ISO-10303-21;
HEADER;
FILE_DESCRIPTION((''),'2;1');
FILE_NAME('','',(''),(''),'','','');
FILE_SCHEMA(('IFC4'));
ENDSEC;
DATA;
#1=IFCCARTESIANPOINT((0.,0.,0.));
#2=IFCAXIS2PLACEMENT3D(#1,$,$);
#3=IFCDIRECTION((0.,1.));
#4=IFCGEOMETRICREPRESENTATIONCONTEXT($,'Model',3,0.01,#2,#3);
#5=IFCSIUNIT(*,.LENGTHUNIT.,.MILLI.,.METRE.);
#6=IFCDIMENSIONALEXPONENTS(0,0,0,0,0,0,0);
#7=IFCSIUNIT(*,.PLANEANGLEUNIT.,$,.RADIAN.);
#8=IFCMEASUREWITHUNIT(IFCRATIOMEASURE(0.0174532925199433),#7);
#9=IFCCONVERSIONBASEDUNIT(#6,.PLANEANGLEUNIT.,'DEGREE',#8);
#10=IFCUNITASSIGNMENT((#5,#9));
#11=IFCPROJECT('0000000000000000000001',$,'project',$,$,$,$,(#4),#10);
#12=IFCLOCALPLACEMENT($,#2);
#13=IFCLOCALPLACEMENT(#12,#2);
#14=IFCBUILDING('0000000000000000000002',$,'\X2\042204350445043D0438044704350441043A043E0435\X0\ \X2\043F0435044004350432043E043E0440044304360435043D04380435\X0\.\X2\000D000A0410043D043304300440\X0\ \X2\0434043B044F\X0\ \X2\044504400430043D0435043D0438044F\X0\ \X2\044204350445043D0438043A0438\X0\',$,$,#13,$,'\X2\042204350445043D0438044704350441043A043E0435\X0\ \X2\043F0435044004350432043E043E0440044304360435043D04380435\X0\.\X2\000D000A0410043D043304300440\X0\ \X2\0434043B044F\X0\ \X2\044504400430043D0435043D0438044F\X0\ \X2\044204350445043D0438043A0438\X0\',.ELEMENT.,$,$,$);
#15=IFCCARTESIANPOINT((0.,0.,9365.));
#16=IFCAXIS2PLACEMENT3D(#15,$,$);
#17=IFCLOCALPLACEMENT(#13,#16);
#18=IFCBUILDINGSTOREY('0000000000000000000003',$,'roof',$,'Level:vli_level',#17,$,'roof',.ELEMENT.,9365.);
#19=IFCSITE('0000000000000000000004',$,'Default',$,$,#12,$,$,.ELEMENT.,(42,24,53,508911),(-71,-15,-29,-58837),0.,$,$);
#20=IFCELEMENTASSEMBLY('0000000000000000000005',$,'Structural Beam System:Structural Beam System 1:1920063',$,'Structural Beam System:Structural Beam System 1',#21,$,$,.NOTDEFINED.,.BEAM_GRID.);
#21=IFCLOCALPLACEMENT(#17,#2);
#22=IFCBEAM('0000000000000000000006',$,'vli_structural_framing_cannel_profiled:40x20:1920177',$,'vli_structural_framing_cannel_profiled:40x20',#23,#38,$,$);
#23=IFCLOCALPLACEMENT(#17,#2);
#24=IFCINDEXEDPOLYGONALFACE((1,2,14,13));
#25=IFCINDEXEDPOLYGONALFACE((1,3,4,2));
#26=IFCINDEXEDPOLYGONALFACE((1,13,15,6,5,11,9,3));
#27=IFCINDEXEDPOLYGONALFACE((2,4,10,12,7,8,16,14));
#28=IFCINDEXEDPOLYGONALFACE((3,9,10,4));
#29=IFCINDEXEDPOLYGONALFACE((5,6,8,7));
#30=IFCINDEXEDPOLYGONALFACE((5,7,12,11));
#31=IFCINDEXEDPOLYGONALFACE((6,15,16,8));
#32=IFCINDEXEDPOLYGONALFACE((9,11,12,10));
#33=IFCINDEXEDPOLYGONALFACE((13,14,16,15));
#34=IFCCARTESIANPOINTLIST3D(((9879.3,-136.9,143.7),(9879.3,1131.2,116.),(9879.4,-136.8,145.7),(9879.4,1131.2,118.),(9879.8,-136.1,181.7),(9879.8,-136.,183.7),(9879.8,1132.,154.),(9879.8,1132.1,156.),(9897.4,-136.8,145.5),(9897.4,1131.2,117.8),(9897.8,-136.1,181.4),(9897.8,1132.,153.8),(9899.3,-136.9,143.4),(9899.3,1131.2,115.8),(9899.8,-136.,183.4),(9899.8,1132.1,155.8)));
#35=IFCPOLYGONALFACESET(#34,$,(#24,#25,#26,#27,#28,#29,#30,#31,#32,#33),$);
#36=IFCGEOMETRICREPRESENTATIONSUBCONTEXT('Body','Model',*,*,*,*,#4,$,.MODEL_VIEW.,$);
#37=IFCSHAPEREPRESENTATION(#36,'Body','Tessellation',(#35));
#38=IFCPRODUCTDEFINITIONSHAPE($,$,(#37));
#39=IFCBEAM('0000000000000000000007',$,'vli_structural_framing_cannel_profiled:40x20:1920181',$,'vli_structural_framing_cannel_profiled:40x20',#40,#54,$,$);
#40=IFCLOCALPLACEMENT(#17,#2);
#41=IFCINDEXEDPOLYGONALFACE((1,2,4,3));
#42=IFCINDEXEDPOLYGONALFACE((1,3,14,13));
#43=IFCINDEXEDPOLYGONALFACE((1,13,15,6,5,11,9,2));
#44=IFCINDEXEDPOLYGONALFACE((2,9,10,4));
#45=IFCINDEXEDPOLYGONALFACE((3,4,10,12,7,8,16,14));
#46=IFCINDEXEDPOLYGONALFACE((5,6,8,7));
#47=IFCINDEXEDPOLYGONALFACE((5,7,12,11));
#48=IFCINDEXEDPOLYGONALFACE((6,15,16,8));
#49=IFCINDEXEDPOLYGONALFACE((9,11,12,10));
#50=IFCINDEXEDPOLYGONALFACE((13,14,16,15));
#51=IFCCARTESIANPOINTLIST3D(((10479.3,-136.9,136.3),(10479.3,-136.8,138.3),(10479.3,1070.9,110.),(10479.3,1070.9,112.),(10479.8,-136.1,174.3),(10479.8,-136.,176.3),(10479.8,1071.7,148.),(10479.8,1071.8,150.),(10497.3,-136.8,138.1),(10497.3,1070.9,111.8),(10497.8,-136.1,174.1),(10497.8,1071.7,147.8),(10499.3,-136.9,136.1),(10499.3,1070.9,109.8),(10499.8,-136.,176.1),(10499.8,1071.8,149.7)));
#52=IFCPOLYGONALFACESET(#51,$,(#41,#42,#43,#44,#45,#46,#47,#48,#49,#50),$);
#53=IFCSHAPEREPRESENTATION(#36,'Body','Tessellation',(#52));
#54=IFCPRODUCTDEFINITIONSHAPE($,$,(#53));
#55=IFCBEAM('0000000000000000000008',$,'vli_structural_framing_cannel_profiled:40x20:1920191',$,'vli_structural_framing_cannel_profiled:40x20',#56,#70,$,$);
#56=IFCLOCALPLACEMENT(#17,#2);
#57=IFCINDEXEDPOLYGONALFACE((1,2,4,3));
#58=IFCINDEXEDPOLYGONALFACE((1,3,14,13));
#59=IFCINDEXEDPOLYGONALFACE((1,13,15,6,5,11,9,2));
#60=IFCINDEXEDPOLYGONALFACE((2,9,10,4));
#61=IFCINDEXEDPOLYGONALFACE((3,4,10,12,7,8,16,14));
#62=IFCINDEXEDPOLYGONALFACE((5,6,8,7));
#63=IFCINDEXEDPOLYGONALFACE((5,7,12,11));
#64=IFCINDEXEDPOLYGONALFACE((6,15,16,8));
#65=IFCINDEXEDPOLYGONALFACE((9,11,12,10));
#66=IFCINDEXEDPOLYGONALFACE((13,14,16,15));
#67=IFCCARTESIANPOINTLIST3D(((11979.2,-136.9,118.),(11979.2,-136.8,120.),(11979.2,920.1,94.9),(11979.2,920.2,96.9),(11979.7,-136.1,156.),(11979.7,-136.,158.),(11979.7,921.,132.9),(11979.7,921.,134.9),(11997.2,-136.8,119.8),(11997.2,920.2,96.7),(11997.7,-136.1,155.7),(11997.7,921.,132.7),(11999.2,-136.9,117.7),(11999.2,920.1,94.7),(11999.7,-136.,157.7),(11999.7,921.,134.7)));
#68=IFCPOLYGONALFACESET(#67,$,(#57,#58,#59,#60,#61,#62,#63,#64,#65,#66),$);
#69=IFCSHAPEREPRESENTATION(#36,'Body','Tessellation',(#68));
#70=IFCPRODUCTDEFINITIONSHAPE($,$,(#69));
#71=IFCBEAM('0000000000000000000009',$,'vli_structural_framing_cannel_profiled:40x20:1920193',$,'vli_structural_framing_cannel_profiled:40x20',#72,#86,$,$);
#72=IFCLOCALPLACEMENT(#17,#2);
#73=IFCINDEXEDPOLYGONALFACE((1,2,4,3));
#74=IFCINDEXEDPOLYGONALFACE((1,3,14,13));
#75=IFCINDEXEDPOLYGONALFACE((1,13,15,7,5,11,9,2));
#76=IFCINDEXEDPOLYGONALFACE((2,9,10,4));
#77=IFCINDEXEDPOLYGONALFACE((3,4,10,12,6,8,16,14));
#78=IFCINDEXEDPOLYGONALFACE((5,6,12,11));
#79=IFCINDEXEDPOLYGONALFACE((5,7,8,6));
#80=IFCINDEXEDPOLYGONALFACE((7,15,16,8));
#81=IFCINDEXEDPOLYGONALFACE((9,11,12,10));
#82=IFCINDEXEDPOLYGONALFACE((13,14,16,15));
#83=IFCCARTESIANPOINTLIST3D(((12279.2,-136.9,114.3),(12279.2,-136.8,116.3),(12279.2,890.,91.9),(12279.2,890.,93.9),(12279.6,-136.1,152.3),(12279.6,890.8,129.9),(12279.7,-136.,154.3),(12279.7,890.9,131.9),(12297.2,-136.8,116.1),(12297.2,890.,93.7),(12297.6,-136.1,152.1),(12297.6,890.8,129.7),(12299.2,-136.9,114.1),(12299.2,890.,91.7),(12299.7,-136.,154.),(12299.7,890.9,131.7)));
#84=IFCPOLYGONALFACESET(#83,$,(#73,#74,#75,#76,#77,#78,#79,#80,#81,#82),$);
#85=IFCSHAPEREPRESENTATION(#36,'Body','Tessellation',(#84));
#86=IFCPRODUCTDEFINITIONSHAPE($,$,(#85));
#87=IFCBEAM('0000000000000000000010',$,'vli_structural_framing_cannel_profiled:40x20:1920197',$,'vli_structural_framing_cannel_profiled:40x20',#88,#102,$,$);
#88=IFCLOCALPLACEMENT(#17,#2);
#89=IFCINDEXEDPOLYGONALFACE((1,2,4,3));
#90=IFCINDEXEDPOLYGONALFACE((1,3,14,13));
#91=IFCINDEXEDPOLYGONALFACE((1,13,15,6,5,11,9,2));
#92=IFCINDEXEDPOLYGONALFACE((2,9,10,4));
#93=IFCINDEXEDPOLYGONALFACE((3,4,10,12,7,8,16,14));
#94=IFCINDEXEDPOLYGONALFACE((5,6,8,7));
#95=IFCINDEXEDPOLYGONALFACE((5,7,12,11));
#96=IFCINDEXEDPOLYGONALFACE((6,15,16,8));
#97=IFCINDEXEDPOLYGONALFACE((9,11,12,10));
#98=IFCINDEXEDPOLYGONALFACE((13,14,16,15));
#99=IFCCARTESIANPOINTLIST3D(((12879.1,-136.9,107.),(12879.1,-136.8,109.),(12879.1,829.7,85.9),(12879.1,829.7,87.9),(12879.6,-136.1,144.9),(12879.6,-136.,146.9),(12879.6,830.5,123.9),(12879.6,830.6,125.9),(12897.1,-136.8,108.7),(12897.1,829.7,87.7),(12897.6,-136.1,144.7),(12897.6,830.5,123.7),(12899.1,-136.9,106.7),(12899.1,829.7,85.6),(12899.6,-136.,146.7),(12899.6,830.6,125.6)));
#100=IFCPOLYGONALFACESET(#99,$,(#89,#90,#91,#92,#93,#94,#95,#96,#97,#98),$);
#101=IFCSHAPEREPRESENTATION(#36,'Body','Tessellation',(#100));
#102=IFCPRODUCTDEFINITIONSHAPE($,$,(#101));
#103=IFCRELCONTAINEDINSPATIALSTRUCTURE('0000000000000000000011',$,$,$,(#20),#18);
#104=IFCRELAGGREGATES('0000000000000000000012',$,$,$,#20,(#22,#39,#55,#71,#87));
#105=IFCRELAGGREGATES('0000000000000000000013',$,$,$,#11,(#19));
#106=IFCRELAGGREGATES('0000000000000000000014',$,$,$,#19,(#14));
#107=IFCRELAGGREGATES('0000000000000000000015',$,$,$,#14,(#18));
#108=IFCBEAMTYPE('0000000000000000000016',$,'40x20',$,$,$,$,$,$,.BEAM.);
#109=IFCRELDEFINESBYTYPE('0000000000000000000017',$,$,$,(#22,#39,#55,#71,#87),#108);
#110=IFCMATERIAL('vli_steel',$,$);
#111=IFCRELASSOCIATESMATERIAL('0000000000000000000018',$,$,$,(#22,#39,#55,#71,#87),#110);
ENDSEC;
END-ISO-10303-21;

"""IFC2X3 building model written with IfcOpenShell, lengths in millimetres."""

from ifc_helpers import new_model, entity, si_unit, converted_unit, direction, frame, origin, place, context, subcontext, project, spatial, polyline, outline, extrude, material, type_object, element, aggregate, save


model = new_model("IFC2X3")

# Units and contexts
model_context = context("Model", 3, precision=0.01, world=origin(), true_north=direction((0.0, 1.0)))
body_context = subcontext(model_context, "Body", "Model", "MODEL_VIEW")
ifc_project = project(units=[si_unit("LENGTHUNIT", "METRE", prefix="MILLI"), converted_unit("PLANEANGLEUNIT", "DEGREE", entity("IfcRatioMeasure", 0.0174532925199433), si_unit("PLANEANGLEUNIT", "RADIAN"), dimensions=[0, 0, 0, 0, 0, 0, 0])], contexts=[model_context])

# Site, building, storey
site_placement = place(None, origin())
site = spatial("IfcSite", under=ifc_project, at=site_placement, Name="Default", CompositionType="ELEMENT", RefLatitude=(42, 24, 53, 508911), RefLongitude=(-71, -15, -29, -58837), RefElevation=0.0)
building_placement = place(site_placement, origin())
building = spatial("IfcBuilding", under=site, at=building_placement, Name="Техническое перевооружение.\r\nАнгар для хранения техники", LongName="Техническое перевооружение.\r\nАнгар для хранения техники", CompositionType="ELEMENT")
storey_placement = place(building_placement, frame((0.0, 0.0, 9365.0)))
storey = spatial("IfcBuildingStorey", under=building, at=storey_placement, Name="roof", ObjectType="Level:vli_level", LongName="roof", CompositionType="ELEMENT", Elevation=9365.0)

# Element assembly, beams
ifc_material = material(Name="vli_steel")
beam_type = type_object("IfcBeamType", Name="40x20", PredefinedType="BEAM")
assembly_1_placement = place(storey_placement, origin())
assembly_1 = element("IfcElementAssembly", 1, at=assembly_1_placement, inside=storey, Name="Structural Beam System:Structural Beam System 1:1920063", ObjectType="Structural Beam System:Structural Beam System 1", AssemblyPlace="NOTDEFINED", PredefinedType="BEAM_GRID")
beam_1_placement = place(assembly_1_placement, frame((9899.2, 1145.4, 155.5), z_axis=(0.0, 0.021793, 0.999763), x_axis=(0.0, -0.999763, 0.021793)))
beam_1 = element("IfcBeam", 2, at=beam_1_placement, type_object=beam_type, material=ifc_material, Name="vli_structural_framing_cannel_profiled:40x20:1920177", ObjectType="vli_structural_framing_cannel_profiled:40x20", context=body_context, shape_type="SweptSolid", body=[
    extrude(outline(polyline([(-10.5, -20.0), (9.5, -20.0), (9.5, -18.0), (-8.5, -18.0), (-8.5, 18.0), (9.5, 18.0), (9.5, 20.0), (-10.5, 20.0), (-10.5, -20.0)])), frame((13.4, -10.1, -19.9), z_axis=(1.0, 0.0, 0.0), x_axis=(0.0, -0.999925, 0.012237)), (0.0, 0.0, 1.0), 1268.4),
])
beam_2_placement = place(assembly_1_placement, frame((10499.2, 1085.1, 149.5), z_axis=(0.0, 0.021793, 0.999763), x_axis=(0.0, -0.999763, 0.021793)))
beam_2 = element("IfcBeam", 3, at=beam_2_placement, type_object=beam_type, material=ifc_material, Name="vli_structural_framing_cannel_profiled:40x20:1920181", ObjectType="vli_structural_framing_cannel_profiled:40x20", context=body_context, shape_type="SweptSolid", body=[
    extrude(outline(polyline([(-10.5, -20.0), (9.5, -20.0), (9.5, -18.0), (-8.5, -18.0), (-8.5, 18.0), (9.5, 18.0), (9.5, 20.0), (-10.5, 20.0), (-10.5, -20.0)])), frame((13.4, -10.1, -19.9), z_axis=(1.0, 0.0, 0.0), x_axis=(0.0, -0.999925, 0.012237)), (0.0, 0.0, 1.0), 1208.1),
])
beam_3_placement = place(assembly_1_placement, frame((11999.1, 934.4, 134.4), z_axis=(0.0, 0.021793, 0.999763), x_axis=(0.0, -0.999763, 0.021793)))
beam_3 = element("IfcBeam", 4, at=beam_3_placement, type_object=beam_type, material=ifc_material, Name="vli_structural_framing_cannel_profiled:40x20:1920191", ObjectType="vli_structural_framing_cannel_profiled:40x20", context=body_context, shape_type="SweptSolid", body=[
    extrude(outline(polyline([(-10.5, -20.0), (9.5, -20.0), (9.5, -18.0), (-8.5, -18.0), (-8.5, 18.0), (9.5, 18.0), (9.5, 20.0), (-10.5, 20.0), (-10.5, -20.0)])), frame((13.4, -10.1, -19.9), z_axis=(1.0, 0.0, 0.0), x_axis=(0.0, -0.999925, 0.012237)), (0.0, 0.0, 1.0), 1057.3),
])
beam_4_placement = place(assembly_1_placement, frame((12299.1, 904.2, 131.4), z_axis=(0.0, 0.021793, 0.999763), x_axis=(0.0, -0.999763, 0.021793)))
beam_4 = element("IfcBeam", 5, at=beam_4_placement, type_object=beam_type, material=ifc_material, Name="vli_structural_framing_cannel_profiled:40x20:1920193", ObjectType="vli_structural_framing_cannel_profiled:40x20", context=body_context, shape_type="SweptSolid", body=[
    extrude(outline(polyline([(-10.5, -20.0), (9.5, -20.0), (9.5, -18.0), (-8.5, -18.0), (-8.5, 18.0), (9.5, 18.0), (9.5, 20.0), (-10.5, 20.0), (-10.5, -20.0)])), frame((13.4, -10.1, -19.9), z_axis=(1.0, 0.0, 0.0), x_axis=(0.0, -0.999925, 0.012237)), (0.0, 0.0, 1.0), 1027.1),
])
beam_5_placement = place(assembly_1_placement, frame((12899.0, 843.9, 125.3), z_axis=(0.0, 0.021793, 0.999763), x_axis=(0.0, -0.999763, 0.021793)))
beam_5 = element("IfcBeam", 6, at=beam_5_placement, type_object=beam_type, material=ifc_material, Name="vli_structural_framing_cannel_profiled:40x20:1920197", ObjectType="vli_structural_framing_cannel_profiled:40x20", context=body_context, shape_type="SweptSolid", body=[
    extrude(outline(polyline([(-10.5, -20.0), (9.5, -20.0), (9.5, -18.0), (-8.5, -18.0), (-8.5, 18.0), (9.5, 18.0), (9.5, 20.0), (-10.5, 20.0), (-10.5, -20.0)])), frame((13.4, -10.1, -19.9), z_axis=(1.0, 0.0, 0.0), x_axis=(0.0, -0.999925, 0.012237)), (0.0, 0.0, 1.0), 966.8),
])
aggregate(assembly_1, [beam_1, beam_2, beam_3, beam_4, beam_5])

save(model, "model.ifc")
